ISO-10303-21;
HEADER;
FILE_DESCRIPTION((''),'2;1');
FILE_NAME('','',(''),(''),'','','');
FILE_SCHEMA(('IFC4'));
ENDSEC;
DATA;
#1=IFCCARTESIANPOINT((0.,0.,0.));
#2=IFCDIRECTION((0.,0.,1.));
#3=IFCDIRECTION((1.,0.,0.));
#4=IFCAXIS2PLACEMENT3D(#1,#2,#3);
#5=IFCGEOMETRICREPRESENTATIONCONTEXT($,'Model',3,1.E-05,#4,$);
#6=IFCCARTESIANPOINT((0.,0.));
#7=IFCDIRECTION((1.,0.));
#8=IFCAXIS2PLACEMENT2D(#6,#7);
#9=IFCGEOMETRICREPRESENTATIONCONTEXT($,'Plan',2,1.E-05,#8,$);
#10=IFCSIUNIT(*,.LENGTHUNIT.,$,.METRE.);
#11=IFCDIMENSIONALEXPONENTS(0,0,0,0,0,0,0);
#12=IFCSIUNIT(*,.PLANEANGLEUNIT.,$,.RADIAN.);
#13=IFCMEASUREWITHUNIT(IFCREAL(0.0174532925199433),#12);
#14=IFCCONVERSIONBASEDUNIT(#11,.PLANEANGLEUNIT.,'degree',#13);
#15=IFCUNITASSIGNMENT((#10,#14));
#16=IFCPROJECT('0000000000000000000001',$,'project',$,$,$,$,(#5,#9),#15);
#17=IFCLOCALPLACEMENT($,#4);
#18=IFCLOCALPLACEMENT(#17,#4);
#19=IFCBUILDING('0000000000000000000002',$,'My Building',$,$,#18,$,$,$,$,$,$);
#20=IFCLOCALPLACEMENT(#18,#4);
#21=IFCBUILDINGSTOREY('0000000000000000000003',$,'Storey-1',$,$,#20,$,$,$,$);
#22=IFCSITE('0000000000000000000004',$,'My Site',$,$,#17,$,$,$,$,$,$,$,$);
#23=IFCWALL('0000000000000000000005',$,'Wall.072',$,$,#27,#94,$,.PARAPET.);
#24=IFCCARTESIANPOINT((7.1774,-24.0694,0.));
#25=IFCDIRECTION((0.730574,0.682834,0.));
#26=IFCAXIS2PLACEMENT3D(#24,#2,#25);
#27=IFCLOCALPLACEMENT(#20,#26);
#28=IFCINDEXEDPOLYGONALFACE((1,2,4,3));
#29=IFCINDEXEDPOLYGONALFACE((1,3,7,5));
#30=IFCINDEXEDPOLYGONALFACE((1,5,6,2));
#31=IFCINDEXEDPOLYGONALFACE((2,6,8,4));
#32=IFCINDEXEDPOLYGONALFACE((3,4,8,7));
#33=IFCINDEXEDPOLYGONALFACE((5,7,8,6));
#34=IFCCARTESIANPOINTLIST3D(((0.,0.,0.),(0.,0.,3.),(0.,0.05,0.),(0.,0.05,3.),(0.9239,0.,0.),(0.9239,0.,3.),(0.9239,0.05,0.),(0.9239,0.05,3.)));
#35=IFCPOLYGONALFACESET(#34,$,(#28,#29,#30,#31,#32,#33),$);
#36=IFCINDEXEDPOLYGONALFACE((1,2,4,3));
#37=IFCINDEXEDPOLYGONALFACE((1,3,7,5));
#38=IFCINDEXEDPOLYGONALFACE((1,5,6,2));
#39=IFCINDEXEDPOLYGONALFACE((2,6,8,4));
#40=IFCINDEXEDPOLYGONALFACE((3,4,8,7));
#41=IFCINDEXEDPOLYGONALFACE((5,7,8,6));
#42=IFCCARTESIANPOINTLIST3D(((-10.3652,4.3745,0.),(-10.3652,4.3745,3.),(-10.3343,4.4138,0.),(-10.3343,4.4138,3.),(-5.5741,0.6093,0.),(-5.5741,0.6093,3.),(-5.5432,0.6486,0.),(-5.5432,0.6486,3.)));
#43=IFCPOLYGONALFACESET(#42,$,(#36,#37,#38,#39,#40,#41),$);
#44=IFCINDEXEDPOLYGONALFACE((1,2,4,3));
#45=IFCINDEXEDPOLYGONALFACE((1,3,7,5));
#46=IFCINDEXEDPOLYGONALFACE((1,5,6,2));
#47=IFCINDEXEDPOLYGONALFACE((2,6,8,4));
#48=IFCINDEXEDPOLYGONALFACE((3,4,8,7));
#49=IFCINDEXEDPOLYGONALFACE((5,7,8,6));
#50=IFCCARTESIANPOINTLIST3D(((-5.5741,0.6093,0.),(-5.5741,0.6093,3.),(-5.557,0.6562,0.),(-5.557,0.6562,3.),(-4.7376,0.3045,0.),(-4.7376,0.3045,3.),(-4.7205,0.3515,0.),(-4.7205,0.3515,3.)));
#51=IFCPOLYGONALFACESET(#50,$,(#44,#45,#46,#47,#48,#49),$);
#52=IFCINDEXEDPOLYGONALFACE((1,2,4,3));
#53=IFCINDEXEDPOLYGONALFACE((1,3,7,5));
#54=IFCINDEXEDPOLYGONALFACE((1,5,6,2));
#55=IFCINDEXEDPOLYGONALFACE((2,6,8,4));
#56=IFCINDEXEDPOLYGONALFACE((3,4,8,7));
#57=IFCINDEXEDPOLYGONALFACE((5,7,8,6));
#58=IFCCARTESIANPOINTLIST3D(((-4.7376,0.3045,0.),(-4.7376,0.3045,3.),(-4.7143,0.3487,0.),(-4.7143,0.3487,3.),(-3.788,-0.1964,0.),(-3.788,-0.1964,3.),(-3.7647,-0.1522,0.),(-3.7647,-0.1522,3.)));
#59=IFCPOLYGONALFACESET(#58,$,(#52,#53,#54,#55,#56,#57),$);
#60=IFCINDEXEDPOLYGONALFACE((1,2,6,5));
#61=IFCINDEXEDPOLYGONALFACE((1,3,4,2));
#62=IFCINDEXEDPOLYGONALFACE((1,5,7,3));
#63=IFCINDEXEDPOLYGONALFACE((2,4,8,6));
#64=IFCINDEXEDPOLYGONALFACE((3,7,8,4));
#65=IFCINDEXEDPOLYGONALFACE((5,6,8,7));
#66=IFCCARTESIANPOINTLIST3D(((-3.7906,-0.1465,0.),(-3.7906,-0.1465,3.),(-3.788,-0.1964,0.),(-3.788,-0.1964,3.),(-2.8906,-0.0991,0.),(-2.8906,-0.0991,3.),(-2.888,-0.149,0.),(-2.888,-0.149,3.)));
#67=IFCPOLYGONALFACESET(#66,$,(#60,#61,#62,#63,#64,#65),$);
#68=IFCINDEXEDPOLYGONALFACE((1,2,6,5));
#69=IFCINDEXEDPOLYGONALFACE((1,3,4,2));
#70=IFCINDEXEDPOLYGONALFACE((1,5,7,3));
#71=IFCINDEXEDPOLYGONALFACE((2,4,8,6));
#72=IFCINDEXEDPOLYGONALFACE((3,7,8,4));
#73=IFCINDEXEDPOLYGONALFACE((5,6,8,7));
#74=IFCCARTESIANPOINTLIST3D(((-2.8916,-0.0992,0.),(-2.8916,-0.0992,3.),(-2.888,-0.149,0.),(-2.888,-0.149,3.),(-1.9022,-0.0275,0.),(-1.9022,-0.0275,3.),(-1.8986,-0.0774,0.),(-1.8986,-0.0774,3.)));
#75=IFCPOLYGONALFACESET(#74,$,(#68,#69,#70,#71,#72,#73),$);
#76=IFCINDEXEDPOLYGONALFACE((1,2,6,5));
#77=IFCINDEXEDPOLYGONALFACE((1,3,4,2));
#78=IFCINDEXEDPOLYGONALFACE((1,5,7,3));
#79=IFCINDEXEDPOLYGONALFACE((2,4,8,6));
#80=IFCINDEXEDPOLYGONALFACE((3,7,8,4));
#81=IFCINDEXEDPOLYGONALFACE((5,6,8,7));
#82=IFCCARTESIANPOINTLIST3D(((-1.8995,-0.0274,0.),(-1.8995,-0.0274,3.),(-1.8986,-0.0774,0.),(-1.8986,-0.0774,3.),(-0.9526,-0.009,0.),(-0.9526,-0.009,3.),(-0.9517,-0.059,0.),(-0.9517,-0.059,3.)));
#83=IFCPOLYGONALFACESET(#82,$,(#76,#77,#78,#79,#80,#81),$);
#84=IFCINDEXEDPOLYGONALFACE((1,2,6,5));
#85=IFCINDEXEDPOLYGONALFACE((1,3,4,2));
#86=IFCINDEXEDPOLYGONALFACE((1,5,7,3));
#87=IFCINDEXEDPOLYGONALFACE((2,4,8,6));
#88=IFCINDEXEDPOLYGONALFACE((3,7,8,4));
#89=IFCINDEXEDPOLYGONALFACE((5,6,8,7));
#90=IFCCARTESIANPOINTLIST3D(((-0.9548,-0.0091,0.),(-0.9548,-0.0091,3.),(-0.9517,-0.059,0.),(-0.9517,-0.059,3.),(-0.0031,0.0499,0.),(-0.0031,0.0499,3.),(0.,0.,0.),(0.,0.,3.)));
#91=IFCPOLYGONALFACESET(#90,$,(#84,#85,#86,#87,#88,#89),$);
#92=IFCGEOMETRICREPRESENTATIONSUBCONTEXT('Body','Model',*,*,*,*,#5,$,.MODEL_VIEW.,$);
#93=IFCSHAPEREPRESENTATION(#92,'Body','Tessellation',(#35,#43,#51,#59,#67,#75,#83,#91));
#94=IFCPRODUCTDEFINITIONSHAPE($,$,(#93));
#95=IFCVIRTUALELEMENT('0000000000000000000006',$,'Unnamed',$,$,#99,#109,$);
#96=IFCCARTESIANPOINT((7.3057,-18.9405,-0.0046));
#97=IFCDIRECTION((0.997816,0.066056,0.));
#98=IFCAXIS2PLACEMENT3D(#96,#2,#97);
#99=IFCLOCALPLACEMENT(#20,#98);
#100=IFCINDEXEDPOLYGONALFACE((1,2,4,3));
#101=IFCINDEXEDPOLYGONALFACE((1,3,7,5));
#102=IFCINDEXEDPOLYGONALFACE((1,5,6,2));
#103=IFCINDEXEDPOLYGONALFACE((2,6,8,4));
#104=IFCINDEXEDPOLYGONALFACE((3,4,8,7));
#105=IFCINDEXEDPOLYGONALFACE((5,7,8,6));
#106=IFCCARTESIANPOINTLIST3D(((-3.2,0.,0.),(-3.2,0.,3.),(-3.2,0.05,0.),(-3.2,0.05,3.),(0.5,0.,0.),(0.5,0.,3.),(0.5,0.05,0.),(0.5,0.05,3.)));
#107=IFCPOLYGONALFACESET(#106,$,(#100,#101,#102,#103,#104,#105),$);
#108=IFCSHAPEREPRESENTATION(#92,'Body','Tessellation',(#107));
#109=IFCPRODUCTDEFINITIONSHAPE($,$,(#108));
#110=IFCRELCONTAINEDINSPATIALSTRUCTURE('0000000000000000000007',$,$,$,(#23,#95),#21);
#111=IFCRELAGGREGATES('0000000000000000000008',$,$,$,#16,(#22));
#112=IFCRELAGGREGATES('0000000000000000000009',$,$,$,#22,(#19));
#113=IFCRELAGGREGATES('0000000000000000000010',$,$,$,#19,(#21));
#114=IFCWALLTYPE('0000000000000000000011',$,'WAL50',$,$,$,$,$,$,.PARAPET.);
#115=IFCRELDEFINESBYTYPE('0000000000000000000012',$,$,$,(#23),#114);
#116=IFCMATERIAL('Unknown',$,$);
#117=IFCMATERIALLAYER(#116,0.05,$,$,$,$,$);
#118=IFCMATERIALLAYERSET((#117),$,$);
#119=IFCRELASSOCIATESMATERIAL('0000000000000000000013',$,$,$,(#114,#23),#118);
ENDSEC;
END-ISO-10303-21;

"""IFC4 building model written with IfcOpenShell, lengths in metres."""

from ifc_helpers import new_model, entity, si_unit, converted_unit, frame, origin_with_axes, origin_2d_with_axis, place, context, subcontext, project, spatial, indexed_curve, outline, extrude, material, layer, layer_set, layer_usage, type_object, element, save


model = new_model("IFC4")

# Units and contexts
model_context = context("Model", 3, precision=1e-05, world=origin_with_axes())
plan_context = context("Plan", 2, precision=1e-05, world=origin_2d_with_axis())
body_context = subcontext(model_context, "Body", "Model", "MODEL_VIEW")
ifc_project = project(units=[si_unit("LENGTHUNIT", "METRE"), converted_unit("PLANEANGLEUNIT", "degree", entity("IfcReal", 0.0174532925199433), si_unit("PLANEANGLEUNIT", "RADIAN"), dimensions=[0, 0, 0, 0, 0, 0, 0])], contexts=[model_context, plan_context])

# Site, building, storey
site_placement = place(None, origin_with_axes())
site = spatial("IfcSite", under=ifc_project, at=site_placement, Name="My Site")
building_placement = place(site_placement, origin_with_axes())
building = spatial("IfcBuilding", under=site, at=building_placement, Name="My Building")
storey_placement = place(building_placement, origin_with_axes())
storey = spatial("IfcBuildingStorey", under=building, at=storey_placement, Name="Storey-1")

# Shared definitions
ifc_material = material(Name="Unknown")

# Wall
ifc_layer_1 = layer(ifc_material, 0.05)
ifc_layer_set_1 = layer_set([ifc_layer_1])
wall_type = type_object("IfcWallType", Name="WAL50", PredefinedType="PARAPET", material=ifc_layer_set_1)
ifc_layer_usage_1 = layer_usage(ifc_layer_set_1, "AXIS2", "POSITIVE", 0.0)
wall_1_placement = place(storey_placement, frame((7.1774, -24.0694, 0.0), z_axis=(0.0, 0.0, 1.0), x_axis=(0.730574, 0.682834, 0.0)))
element("IfcWall", 1, at=wall_1_placement, inside=storey, type_object=wall_type, material=ifc_layer_usage_1, Name="Wall.072", PredefinedType="PARAPET", context=body_context, shape_type="SweptSolid", body=[
    extrude(outline(indexed_curve([(0.0, 0.0), (0.0, 0.05), (0.9239, 0.05), (0.9239, 0.0), (0.0, 0.0)], self_intersect=False)), origin_with_axes(), (0.0, 0.0, 1.0), 3.0),
    extrude(outline(indexed_curve([(0.0, 0.0), (0.0, 0.05), (6.0935, 0.05), (6.0935, 0.0), (0.0, 0.0)], self_intersect=False)), frame((-10.3652, 4.3745, 0.0), z_axis=(0.0, 0.0, 1.0), x_axis=(0.786255, -0.617902, 0.0)), (0.0, 0.0, 1.0), 3.0),
    extrude(outline(indexed_curve([(0.0, 0.0), (0.0, 0.05), (0.8903, 0.05), (0.8903, 0.0), (0.0, 0.0)], self_intersect=False)), frame((-5.5741, 0.6093, 0.0), z_axis=(0.0, 0.0, 1.0), x_axis=(0.939589, -0.342303, 0.0)), (0.0, 0.0, 1.0), 3.0),
    extrude(outline(indexed_curve([(0.0, 0.0), (0.0, 0.05), (1.0737, 0.05), (1.0737, 0.0), (0.0, 0.0)], self_intersect=False)), frame((-4.7376, 0.3045, 0.0), z_axis=(0.0, 0.0, 1.0), x_axis=(0.884488, -0.466563, 0.0)), (0.0, 0.0, 1.0), 3.0),
    extrude(outline(indexed_curve([(0.0, 0.0), (0.0, 0.05), (0.9012, 0.05), (0.9012, 0.0), (0.0, 0.0)], self_intersect=False)), frame((-3.788, -0.1964, 0.0), z_axis=(0.0, 0.0, 1.0), x_axis=(0.998617, 0.052576, 0.0)), (0.0, 0.0, 1.0), 3.0),
    extrude(outline(indexed_curve([(0.0, 0.0), (0.0, 0.05), (0.992, 0.05), (0.992, 0.0), (0.0, 0.0)], self_intersect=False)), frame((-2.888, -0.149, 0.0), z_axis=(0.0, 0.0, 1.0), x_axis=(0.99739, 0.072202, 0.0)), (0.0, 0.0, 1.0), 3.0),
    extrude(outline(indexed_curve([(0.0, 0.0), (0.0, 0.05), (0.9471, 0.05), (0.9471, 0.0), (0.0, 0.0)], self_intersect=False)), frame((-1.8986, -0.0774, 0.0), z_axis=(0.0, 0.0, 1.0), x_axis=(0.999811, 0.01942, 0.0)), (0.0, 0.0, 1.0), 3.0),
    extrude(outline(indexed_curve([(0.0, 0.0), (0.0, 0.05), (0.9535, 0.05), (0.9535, 0.0), (0.0, 0.0)], self_intersect=False)), frame((-0.9517, -0.059, 0.0), z_axis=(0.0, 0.0, 1.0), x_axis=(0.998083, 0.061896, 0.0)), (0.0, 0.0, 1.0), 3.0),
])

# Virtual element
virtual_element_placement = place(storey_placement, frame((7.3057, -18.9405, -0.0046), z_axis=(0.0, 0.0, 1.0), x_axis=(0.997816, 0.066056, 0.0)))
element("IfcVirtualElement", 2, at=virtual_element_placement, inside=storey, Name="Unnamed", context=body_context, shape_type="SolidModel", body=[
    extrude(outline(indexed_curve([(-3.2, 0.0), (0.5, 0.0), (0.5, 0.05), (-3.2, 0.05), (-3.2, 0.0)])), origin_with_axes(), (0.0, 0.0, 1.0), 3.0),
])

save(model, "model.ifc")
